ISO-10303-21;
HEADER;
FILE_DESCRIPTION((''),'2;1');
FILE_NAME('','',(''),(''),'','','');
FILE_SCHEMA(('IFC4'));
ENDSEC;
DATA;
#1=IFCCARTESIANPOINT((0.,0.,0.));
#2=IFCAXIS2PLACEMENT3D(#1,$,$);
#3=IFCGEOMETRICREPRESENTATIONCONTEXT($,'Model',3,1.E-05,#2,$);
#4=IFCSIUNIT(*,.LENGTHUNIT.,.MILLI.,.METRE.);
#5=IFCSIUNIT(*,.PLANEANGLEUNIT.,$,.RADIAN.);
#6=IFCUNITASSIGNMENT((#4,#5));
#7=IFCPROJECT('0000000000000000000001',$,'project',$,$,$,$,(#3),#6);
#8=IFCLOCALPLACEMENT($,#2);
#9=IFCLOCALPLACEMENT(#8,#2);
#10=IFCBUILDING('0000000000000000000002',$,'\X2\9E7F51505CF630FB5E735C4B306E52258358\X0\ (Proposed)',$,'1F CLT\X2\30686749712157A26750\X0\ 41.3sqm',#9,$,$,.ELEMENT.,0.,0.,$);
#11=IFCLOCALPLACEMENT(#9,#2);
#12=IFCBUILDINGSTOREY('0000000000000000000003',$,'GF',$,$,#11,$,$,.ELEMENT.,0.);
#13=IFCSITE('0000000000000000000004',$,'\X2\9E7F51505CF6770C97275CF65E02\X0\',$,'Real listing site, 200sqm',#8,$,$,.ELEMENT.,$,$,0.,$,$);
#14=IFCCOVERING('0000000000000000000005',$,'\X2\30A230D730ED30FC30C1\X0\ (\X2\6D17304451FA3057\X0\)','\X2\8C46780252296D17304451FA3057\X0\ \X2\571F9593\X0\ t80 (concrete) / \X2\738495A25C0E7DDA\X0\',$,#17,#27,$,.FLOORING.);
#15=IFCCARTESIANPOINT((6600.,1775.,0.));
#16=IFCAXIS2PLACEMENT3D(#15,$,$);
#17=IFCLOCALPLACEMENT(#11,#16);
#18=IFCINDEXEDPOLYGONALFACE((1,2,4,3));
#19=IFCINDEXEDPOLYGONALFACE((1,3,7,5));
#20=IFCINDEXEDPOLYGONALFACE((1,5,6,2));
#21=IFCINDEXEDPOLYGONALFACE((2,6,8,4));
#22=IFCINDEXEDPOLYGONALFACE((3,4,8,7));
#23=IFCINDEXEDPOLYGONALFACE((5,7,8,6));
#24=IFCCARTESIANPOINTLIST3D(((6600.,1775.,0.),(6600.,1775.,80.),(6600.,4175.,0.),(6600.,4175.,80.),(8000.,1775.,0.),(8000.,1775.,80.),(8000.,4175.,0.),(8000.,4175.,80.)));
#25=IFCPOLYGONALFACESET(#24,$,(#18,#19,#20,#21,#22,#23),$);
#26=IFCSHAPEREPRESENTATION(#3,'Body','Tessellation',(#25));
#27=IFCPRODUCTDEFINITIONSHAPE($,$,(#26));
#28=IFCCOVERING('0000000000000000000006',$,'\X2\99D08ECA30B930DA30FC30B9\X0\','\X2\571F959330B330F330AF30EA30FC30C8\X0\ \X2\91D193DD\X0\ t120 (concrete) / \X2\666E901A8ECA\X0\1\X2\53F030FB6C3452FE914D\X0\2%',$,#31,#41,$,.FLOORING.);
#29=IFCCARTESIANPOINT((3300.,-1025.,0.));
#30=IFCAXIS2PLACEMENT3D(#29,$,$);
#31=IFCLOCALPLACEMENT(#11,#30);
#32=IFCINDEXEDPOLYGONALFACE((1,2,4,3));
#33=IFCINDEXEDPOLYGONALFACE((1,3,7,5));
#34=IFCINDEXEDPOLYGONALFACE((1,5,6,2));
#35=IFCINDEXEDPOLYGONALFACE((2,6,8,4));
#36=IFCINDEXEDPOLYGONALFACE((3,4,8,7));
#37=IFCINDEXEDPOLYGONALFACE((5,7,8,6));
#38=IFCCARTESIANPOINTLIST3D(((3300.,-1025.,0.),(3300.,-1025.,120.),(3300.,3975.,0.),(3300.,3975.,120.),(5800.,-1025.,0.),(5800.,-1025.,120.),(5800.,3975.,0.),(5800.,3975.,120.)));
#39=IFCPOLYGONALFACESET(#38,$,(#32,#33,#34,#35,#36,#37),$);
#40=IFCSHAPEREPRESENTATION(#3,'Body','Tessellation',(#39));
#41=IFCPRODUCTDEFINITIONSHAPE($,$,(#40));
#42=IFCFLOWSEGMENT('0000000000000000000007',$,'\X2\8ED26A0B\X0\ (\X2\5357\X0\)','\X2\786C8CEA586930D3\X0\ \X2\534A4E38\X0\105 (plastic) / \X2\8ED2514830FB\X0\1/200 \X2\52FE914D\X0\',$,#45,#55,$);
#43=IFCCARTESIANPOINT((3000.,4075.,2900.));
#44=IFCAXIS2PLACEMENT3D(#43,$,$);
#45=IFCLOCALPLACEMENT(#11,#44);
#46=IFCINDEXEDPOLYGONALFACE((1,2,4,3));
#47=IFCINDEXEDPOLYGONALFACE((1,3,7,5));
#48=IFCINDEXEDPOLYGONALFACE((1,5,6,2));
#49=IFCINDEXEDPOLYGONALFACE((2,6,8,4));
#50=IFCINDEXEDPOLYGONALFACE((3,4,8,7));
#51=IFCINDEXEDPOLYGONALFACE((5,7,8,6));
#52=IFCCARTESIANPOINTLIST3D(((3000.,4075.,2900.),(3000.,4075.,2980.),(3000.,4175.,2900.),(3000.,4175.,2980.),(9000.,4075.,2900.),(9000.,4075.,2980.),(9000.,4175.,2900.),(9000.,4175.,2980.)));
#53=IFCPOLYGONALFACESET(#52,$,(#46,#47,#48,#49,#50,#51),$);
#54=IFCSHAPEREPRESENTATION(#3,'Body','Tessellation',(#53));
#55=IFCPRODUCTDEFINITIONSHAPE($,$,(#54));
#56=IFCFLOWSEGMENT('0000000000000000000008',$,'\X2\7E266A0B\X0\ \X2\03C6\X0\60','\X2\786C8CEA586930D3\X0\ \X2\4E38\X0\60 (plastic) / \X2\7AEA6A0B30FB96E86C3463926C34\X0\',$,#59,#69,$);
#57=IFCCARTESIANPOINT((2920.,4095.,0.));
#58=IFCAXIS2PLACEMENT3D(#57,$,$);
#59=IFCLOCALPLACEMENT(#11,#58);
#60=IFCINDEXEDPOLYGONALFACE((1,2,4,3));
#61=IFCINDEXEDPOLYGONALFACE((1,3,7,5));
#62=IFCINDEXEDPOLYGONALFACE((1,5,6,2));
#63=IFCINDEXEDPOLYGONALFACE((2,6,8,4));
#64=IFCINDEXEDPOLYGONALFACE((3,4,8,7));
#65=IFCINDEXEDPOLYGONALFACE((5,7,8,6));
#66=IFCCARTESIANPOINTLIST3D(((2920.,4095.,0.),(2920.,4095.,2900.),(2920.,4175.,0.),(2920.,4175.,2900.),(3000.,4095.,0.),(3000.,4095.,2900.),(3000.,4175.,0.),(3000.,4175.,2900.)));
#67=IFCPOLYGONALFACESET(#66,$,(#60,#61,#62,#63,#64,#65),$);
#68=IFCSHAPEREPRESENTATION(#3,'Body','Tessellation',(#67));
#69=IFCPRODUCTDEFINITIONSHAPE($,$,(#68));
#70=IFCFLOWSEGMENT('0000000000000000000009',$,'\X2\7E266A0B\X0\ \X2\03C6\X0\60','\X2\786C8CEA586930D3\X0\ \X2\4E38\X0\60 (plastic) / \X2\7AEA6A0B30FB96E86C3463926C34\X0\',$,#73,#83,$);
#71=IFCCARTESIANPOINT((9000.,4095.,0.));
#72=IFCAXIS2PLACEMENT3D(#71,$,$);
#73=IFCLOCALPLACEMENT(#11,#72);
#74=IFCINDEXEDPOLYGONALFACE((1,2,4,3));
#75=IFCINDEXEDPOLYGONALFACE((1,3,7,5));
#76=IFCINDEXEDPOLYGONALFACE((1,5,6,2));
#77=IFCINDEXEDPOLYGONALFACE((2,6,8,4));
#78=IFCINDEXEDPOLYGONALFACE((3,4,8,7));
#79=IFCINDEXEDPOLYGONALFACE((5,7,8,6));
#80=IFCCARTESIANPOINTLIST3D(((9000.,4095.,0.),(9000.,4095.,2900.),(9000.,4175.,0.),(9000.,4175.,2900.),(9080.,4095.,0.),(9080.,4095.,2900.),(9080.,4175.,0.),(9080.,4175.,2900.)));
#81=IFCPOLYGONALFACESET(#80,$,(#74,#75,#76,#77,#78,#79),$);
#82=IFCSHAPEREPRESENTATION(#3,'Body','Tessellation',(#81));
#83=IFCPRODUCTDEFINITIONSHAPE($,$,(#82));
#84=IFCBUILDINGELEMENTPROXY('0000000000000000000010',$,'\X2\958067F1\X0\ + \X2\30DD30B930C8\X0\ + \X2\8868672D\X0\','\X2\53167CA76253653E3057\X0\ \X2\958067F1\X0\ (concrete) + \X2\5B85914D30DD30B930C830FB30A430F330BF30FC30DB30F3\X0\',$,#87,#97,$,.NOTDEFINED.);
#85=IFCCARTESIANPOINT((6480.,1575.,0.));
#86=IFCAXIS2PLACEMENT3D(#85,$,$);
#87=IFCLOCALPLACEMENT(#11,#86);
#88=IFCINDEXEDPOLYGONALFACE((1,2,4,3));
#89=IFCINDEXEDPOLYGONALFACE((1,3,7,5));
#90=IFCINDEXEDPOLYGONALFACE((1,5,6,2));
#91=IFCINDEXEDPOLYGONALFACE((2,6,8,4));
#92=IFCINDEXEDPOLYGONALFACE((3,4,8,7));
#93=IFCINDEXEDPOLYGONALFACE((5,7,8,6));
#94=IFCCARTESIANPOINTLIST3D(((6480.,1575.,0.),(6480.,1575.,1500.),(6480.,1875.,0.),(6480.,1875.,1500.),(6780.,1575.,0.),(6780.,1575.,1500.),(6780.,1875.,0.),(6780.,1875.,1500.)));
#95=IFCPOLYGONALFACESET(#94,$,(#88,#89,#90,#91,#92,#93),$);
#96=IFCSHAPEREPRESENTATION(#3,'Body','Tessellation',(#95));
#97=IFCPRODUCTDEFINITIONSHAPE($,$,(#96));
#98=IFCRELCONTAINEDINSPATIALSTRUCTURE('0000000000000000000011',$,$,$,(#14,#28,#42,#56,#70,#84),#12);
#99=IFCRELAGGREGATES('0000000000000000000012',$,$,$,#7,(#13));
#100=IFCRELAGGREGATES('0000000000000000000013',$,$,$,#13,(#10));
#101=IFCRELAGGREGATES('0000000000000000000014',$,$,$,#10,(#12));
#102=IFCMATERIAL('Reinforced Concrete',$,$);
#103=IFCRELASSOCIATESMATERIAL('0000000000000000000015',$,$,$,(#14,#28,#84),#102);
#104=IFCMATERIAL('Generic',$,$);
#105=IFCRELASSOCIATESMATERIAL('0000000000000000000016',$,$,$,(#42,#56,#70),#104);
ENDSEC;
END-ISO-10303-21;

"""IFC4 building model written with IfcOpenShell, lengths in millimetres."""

from ifc_helpers import new_model, si_unit, frame, frame_2d, origin, place, context, project, spatial, rectangle, extrude, material, element, save


model = new_model("IFC4")

# Units and contexts
model_context = context("Model", 3, precision=1e-05, world=origin())
ifc_project = project(units=[si_unit("LENGTHUNIT", "METRE", prefix="MILLI"), si_unit("PLANEANGLEUNIT", "RADIAN")], contexts=[model_context])

# Site, building, storey
site_placement = place(None, origin())
site = spatial("IfcSite", under=ifc_project, at=site_placement, Name="鹿児島県霧島市", ObjectType="Real listing site, 200sqm", CompositionType="ELEMENT", RefElevation=0.0)
building_placement = place(site_placement, origin())
building = spatial("IfcBuilding", under=site, at=building_placement, Name="鹿児島・平屋の別荘 (Proposed)", ObjectType="1F CLTと杉無垢材 41.3sqm", CompositionType="ELEMENT", ElevationOfRefHeight=0.0, ElevationOfTerrain=0.0)
storey_placement = place(building_placement, origin())
storey = spatial("IfcBuildingStorey", under=building, at=storey_placement, Name="GF", CompositionType="ELEMENT", Elevation=0.0)

# Shared definitions
ifc_material_1 = material(Name="Reinforced Concrete")

# Coverings
ifc_material_2 = material(Name="Generic")
covering_1_placement = place(storey_placement, frame((6600.0, 1775.0, 0.0)))
element("IfcCovering", 1, at=covering_1_placement, inside=storey, material=ifc_material_1, Name="アプローチ (洗い出し)", Description="豆砂利洗い出し 土間 t80 (concrete) / 玄関導線", PredefinedType="FLOORING", context=model_context, shape_type="SweptSolid", body=[
    extrude(rectangle(XDim=1400.0, YDim=2400.0, at=frame_2d((700.0, 1200.0))), frame((6600.0, 1775.0, 0.0)), (0.0, 0.0, 1.0), 80.0),
])
covering_2_placement = place(storey_placement, frame((3300.0, -1025.0, 0.0)))
element("IfcCovering", 2, at=covering_2_placement, inside=storey, material=ifc_material_1, Name="駐車スペース", Description="土間コンクリート 金鏝 t120 (concrete) / 普通車1台・水勾配2%", PredefinedType="FLOORING", context=model_context, shape_type="SweptSolid", body=[
    extrude(rectangle(XDim=2500.0, YDim=5000.0, at=frame_2d((1250.0, 2500.0))), frame((3300.0, -1025.0, 0.0)), (0.0, 0.0, 1.0), 120.0),
])

# Flow segments
flow_segment_1_placement = place(storey_placement, frame((3000.0, 4075.0, 2900.0)))
element("IfcFlowSegment", 3, at=flow_segment_1_placement, inside=storey, material=ifc_material_2, Name="軒樋 (南)", Description="硬質塩ビ 半丸105 (plastic) / 軒先・1/200 勾配", context=model_context, shape_type="SweptSolid", body=[
    extrude(rectangle(XDim=6000.0, YDim=100.0, at=frame_2d((3000.0, 50.0))), frame((3000.0, 4075.0, 2900.0)), (0.0, 0.0, 1.0), 80.0),
])
flow_segment_2_placement = place(storey_placement, frame((2920.0, 4095.0, 0.0)))
element("IfcFlowSegment", 4, at=flow_segment_2_placement, inside=storey, material=ifc_material_2, Name="縦樋 φ60", Description="硬質塩ビ 丸60 (plastic) / 竪樋・雨水排水", context=model_context, shape_type="SweptSolid", body=[
    extrude(rectangle(XDim=80.0, YDim=80.0, at=frame_2d((40.0, 40.0))), frame((2920.0, 4095.0, 0.0)), (0.0, 0.0, 1.0), 2900.0),
])
flow_segment_3_placement = place(storey_placement, frame((9000.0, 4095.0, 0.0)))
element("IfcFlowSegment", 5, at=flow_segment_3_placement, inside=storey, material=ifc_material_2, Name="縦樋 φ60", Description="硬質塩ビ 丸60 (plastic) / 竪樋・雨水排水", context=model_context, shape_type="SweptSolid", body=[
    extrude(rectangle(XDim=80.0, YDim=80.0, at=frame_2d((40.0, 40.0))), frame((9000.0, 4095.0, 0.0)), (0.0, 0.0, 1.0), 2900.0),
])

# Building element proxy
proxy_placement = place(storey_placement, frame((6480.0, 1575.0, 0.0)))
element("IfcBuildingElementProxy", 6, at=proxy_placement, inside=storey, material=ifc_material_1, Name="門柱 + ポスト + 表札", Description="化粧打放し 門柱 (concrete) + 宅配ポスト・インターホン", PredefinedType="NOTDEFINED", context=model_context, shape_type="SweptSolid", body=[
    extrude(rectangle(XDim=300.0, YDim=300.0, at=frame_2d((150.0, 150.0))), frame((6480.0, 1575.0, 0.0)), (0.0, 0.0, 1.0), 1500.0),
])

save(model, "model.ifc")
